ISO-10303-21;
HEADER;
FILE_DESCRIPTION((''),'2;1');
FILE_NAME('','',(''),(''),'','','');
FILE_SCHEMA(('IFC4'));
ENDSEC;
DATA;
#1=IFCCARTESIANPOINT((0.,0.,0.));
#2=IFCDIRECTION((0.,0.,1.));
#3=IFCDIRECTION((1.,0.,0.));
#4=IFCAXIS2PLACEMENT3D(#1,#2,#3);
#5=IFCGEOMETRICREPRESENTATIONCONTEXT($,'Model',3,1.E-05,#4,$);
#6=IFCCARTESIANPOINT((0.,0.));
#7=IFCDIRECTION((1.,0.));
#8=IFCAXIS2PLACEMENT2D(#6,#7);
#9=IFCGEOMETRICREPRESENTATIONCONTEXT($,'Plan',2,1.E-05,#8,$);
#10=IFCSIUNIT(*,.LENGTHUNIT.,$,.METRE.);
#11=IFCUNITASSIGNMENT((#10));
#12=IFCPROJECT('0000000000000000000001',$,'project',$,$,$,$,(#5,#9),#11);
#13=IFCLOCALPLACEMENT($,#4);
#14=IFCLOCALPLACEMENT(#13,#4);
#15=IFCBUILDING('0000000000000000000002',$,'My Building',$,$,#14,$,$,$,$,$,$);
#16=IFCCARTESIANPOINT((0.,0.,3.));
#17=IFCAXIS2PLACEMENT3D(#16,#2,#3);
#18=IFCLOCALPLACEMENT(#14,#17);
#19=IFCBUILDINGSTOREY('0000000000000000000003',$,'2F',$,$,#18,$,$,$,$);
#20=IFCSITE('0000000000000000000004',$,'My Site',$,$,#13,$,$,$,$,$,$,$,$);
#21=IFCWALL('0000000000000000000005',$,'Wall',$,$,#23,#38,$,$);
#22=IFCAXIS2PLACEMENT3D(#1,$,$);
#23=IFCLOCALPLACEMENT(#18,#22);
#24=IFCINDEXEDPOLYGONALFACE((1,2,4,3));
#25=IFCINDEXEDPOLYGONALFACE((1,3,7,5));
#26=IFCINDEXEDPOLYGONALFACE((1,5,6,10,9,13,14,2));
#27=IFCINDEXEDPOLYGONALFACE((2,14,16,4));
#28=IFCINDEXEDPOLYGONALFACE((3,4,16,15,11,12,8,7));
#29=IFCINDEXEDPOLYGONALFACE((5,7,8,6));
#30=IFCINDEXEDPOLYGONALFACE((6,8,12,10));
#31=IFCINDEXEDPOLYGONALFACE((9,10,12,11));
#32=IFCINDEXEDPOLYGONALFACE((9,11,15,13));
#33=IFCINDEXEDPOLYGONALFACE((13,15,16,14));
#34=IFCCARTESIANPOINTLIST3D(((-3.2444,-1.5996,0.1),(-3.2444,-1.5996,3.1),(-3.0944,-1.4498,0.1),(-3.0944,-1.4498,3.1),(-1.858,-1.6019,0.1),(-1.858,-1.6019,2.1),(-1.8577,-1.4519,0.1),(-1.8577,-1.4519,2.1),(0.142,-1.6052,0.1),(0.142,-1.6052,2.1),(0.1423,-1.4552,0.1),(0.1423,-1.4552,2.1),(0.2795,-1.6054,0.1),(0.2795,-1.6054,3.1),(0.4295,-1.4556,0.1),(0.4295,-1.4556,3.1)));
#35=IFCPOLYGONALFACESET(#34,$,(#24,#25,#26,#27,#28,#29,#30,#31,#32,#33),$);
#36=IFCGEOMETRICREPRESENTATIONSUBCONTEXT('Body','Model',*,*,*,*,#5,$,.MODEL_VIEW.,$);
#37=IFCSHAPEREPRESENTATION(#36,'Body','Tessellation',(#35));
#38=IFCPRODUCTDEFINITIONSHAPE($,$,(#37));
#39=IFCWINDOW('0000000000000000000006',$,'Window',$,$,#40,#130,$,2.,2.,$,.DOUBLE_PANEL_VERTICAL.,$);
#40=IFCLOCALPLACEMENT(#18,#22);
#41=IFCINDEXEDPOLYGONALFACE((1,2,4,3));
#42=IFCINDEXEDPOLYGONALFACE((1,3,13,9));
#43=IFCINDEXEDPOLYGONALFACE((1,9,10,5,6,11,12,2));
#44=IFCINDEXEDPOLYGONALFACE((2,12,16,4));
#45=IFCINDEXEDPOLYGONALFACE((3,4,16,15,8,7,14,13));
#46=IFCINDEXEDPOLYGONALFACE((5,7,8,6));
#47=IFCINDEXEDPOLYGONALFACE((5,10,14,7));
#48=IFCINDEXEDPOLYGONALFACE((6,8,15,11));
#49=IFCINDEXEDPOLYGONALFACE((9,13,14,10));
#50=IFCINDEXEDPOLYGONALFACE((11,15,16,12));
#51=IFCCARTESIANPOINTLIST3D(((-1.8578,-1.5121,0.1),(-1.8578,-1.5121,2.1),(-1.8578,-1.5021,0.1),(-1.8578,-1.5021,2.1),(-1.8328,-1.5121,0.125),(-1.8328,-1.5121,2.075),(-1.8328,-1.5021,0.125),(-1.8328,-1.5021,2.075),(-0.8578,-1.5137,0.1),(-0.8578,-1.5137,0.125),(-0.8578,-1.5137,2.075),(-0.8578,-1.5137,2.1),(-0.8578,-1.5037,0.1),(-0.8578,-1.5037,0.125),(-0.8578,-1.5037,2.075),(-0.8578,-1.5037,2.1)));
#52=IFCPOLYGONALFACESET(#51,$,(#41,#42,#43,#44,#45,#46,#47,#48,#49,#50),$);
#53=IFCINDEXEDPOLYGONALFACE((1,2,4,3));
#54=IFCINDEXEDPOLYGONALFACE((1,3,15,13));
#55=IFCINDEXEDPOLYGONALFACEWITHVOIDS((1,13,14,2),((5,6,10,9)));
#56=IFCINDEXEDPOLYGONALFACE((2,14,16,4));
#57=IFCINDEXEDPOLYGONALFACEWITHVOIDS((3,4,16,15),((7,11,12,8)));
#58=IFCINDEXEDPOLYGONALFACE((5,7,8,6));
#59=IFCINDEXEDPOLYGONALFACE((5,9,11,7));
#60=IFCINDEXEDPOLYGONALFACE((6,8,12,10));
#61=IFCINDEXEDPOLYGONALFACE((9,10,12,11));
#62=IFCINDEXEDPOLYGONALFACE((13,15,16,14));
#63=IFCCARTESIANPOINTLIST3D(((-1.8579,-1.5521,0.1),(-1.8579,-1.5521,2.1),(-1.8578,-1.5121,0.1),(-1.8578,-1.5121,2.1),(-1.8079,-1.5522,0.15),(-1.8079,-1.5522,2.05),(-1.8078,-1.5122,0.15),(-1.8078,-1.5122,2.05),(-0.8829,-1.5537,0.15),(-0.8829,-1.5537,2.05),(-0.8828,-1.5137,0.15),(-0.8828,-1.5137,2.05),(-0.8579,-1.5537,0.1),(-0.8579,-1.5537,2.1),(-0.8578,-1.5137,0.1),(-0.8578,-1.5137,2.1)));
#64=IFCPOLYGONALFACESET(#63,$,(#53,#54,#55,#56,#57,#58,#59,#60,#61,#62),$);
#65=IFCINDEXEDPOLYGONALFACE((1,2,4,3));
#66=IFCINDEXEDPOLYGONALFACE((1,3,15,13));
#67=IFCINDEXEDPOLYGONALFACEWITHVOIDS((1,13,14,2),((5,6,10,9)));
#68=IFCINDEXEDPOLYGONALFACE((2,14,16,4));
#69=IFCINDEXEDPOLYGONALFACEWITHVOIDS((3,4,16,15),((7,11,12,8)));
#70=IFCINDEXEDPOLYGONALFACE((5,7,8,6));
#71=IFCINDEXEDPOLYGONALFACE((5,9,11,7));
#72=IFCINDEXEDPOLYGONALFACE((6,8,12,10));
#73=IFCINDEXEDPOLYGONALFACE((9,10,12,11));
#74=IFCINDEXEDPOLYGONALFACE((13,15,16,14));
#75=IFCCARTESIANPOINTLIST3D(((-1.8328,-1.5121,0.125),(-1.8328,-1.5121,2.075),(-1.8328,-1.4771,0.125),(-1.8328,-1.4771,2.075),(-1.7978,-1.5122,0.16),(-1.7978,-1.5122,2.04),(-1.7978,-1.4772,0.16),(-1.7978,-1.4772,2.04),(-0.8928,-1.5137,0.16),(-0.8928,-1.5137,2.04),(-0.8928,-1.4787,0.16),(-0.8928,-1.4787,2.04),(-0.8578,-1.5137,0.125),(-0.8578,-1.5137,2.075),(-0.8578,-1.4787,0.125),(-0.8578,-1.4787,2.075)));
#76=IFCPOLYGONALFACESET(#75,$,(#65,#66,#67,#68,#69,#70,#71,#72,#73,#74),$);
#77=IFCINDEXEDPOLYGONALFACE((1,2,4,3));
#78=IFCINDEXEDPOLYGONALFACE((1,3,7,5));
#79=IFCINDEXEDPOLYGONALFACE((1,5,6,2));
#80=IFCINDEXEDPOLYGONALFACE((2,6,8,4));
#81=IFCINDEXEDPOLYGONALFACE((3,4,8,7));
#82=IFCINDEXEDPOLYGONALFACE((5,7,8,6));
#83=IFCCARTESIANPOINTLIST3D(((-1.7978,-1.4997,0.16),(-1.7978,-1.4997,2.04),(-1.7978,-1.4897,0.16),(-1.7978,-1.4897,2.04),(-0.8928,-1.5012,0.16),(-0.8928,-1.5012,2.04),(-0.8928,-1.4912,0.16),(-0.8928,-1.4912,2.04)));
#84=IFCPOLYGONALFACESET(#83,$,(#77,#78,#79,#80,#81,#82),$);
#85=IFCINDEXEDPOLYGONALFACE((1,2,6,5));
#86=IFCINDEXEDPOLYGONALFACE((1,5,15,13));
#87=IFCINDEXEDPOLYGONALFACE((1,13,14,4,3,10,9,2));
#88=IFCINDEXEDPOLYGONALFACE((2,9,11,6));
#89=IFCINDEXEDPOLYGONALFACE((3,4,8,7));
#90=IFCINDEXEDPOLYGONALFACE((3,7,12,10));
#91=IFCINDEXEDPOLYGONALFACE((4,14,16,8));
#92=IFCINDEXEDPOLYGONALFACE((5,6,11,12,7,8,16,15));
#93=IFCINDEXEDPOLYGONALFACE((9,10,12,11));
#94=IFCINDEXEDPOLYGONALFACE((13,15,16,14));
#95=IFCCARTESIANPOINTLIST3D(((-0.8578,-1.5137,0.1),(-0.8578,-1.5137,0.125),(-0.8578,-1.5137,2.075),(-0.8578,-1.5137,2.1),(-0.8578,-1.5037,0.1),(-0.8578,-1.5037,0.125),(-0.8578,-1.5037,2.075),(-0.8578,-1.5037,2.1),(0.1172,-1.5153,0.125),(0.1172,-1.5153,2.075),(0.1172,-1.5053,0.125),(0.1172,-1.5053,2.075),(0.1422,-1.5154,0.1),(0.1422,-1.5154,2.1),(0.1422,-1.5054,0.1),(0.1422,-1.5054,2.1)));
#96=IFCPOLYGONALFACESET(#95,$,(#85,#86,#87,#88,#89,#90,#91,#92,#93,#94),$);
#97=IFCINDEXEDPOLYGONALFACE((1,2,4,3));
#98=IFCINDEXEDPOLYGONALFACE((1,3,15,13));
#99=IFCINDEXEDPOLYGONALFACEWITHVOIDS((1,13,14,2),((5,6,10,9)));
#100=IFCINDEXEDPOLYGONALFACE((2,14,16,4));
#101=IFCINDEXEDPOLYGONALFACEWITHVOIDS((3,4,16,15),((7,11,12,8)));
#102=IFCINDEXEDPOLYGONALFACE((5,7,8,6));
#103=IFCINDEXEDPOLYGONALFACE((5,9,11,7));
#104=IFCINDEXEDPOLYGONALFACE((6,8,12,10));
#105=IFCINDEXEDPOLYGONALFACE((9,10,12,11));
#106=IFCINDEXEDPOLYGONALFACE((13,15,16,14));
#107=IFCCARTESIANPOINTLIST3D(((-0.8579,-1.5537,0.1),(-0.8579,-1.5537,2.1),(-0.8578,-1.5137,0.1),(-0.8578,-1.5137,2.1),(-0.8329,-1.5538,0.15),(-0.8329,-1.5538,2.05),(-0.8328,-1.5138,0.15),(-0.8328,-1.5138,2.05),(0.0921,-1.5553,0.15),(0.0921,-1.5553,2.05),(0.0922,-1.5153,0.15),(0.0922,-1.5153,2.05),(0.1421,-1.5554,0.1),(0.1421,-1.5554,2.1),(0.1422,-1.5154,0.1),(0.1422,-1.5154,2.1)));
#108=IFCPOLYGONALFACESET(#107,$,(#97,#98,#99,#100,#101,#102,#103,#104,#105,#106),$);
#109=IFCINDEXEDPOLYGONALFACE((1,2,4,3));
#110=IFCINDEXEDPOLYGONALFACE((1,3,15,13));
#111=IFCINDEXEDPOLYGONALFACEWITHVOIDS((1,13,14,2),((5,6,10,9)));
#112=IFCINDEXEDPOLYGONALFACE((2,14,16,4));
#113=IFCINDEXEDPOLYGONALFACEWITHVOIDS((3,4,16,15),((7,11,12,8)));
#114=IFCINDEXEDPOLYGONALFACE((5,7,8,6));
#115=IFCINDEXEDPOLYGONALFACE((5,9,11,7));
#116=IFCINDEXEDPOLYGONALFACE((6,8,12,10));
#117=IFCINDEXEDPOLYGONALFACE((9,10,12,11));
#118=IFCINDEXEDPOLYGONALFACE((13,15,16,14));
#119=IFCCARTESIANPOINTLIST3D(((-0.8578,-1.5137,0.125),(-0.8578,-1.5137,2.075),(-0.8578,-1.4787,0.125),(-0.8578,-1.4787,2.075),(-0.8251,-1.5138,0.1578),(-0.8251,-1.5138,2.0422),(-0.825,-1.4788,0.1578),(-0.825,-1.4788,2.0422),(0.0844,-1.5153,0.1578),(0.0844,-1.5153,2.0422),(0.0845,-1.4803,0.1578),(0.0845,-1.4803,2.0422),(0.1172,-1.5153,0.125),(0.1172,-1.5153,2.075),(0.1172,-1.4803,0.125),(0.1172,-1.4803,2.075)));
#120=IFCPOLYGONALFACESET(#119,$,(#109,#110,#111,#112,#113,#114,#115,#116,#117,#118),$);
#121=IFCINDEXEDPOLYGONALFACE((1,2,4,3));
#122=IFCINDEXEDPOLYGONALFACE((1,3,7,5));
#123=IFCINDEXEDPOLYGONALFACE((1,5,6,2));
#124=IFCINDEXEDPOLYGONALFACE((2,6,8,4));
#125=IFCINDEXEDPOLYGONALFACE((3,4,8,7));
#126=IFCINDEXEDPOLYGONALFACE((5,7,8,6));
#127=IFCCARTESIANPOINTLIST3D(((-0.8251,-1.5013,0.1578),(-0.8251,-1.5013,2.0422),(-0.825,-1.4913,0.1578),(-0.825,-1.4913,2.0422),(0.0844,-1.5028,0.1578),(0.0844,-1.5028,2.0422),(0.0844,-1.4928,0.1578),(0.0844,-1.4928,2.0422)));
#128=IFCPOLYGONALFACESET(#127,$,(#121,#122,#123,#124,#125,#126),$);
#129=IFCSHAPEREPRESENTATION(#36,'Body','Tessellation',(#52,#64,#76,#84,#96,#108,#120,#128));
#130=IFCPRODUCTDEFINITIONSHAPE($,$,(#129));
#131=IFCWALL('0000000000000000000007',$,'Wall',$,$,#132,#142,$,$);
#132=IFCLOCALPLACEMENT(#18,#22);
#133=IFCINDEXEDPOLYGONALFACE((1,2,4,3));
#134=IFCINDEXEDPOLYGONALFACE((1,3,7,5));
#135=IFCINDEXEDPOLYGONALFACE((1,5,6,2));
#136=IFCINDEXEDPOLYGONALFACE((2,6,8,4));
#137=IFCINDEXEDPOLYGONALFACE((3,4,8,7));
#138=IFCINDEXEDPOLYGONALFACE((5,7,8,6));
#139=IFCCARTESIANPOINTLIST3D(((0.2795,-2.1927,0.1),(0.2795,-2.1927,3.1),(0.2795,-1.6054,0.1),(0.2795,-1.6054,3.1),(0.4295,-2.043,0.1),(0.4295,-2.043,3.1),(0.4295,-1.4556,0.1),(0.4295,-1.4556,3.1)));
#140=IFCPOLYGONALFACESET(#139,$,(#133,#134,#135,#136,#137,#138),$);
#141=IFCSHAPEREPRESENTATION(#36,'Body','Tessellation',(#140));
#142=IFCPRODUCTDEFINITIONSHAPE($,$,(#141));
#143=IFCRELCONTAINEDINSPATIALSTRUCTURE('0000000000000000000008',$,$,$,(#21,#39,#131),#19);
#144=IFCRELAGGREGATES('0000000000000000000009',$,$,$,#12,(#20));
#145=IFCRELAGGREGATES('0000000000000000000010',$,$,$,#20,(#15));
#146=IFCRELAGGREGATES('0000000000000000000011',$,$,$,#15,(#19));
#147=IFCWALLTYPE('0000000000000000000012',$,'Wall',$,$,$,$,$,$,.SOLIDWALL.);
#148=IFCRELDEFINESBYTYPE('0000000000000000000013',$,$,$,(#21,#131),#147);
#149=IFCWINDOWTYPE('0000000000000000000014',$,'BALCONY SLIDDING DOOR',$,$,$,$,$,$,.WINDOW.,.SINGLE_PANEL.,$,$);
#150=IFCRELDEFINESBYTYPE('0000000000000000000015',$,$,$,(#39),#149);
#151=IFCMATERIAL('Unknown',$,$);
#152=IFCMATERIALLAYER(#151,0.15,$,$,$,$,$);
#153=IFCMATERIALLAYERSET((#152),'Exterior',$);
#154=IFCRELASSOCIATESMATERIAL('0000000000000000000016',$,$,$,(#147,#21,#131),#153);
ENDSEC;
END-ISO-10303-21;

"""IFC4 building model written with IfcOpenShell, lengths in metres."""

from ifc_helpers import new_model, entity, si_unit, frame, origin_with_axes, origin_2d_with_axis, place, context, subcontext, project, spatial, line, indexed_curve, outline, extrude, shape, source, transform, mapped, material, layer, layer_set, layer_usage, type_object, type_shapes, element, fill, save


model = new_model("IFC4")

# Units and contexts
model_context = context("Model", 3, precision=1e-05, world=origin_with_axes())
plan_context = context("Plan", 2, precision=1e-05, world=origin_2d_with_axis())
body_context_1 = subcontext(model_context, "Body", "Model", "MODEL_VIEW")
body_context_2 = subcontext(plan_context, "Body", "Plan", "PLAN_VIEW")
ifc_project = project(units=[si_unit("LENGTHUNIT", "METRE")], contexts=[model_context, plan_context])

# Site, building, storey
site_placement = place(None, origin_with_axes())
site = spatial("IfcSite", under=ifc_project, at=site_placement, Name="My Site")
building_placement = place(site_placement, origin_with_axes())
building = spatial("IfcBuilding", under=site, at=building_placement, Name="My Building")
storey_placement = place(building_placement, frame((0.0, 0.0, 3.0), z_axis=(0.0, 0.0, 1.0), x_axis=(1.0, 0.0, 0.0)))
storey = spatial("IfcBuildingStorey", under=building, at=storey_placement, Name="2F")

# Shared definitions
ifc_material = material(Name="Unknown")

# Shared definitions
ifc_layer_1 = layer(ifc_material, 0.15)
ifc_layer_set_1 = layer_set([ifc_layer_1], Name="Exterior")
wall_type_1 = type_object("IfcWallType", Name="Wall", PredefinedType="SOLIDWALL", material=ifc_layer_set_1)

# Wall, opening, window
ifc_layer_usage_1 = layer_usage(ifc_layer_set_1, "AXIS2", "POSITIVE", 0.0)
wall_1_placement = place(storey_placement, frame((-3.2444, -1.5996, 0.1), z_axis=(0.0, 0.0, 1.0), x_axis=(0.999999, -0.00165, 0.0)))
wall_1 = element("IfcWall", 1, at=wall_1_placement, inside=storey, type_object=wall_type_1, material=ifc_layer_usage_1, Name="Wall", context=body_context_1, shape_type="SweptSolid", body=[
    extrude(outline(indexed_curve([(0.0, 0.0), (0.1498, 0.15), (3.6737, 0.15), (3.5239, 0.0)], segments=[line(1, 2, 3, 4, 1)])), origin_with_axes(), (0.0, 0.0, 1.0), 3.0),
])
shared_shape_1 = source(origin_with_axes(), body_context_1, "Body", "SweptSolid", [
    extrude(outline(indexed_curve([(0.0, 0.0), (2.0, 0.0), (2.0, 2.0), (0.0, 2.0)], segments=[line(1, 2, 3, 4, 1)])), frame((0.0, -0.6, 0.0), z_axis=(0.0, -1.0, 0.0), x_axis=(1.0, 0.0, 0.0)), (0.0, 0.0, -1.0), 1.2),
])
opening_1_placement = place(wall_1_placement, frame((1.3864, -0.0002, 0.0), z_axis=(0.0, 0.0, 1.0), x_axis=(1.0, 0.0, 0.0)))
opening_1 = element("IfcOpeningElement", 2, at=opening_1_placement, cuts=wall_1, PredefinedType="OPENING", context=body_context_1, shape_type="MappedRepresentation", body=[
    mapped(shared_shape_1, transform((0.0, 0.0, 0.0), x_axis=(1.0, 0.0, 0.0), y_axis=(0.0, 1.0, 0.0), z_axis=(0.0, 0.0, 1.0), scale=1.0)),
])
window_type_1 = type_object("IfcWindowType", Name="BALCONY SLIDDING DOOR", PartitioningType="SINGLE_PANEL", PredefinedType="WINDOW")
shared_shape_2 = source(origin_with_axes(), body_context_1, "Body", "SweptSolid", [
    extrude(outline(indexed_curve([(1.0, 0.0), (0.0, 0.0), (0.0, 2.0), (1.0, 2.0), (1.0, 1.975), (0.025, 1.975), (0.025, 0.025), (1.0, 0.025)], segments=[line(1, 2, 3, 4, 5, 6, 7, 8, 1)])), frame((0.0, 0.09, 0.0), z_axis=(0.0, -1.0, 0.0), x_axis=(1.0, 0.0, 0.0)), (0.0, 0.0, -1.0), 0.01),
    extrude(outline(indexed_curve([(0.0, 0.0), (1.0, 0.0), (1.0, 2.0), (0.0, 2.0)], segments=[line(1, 2, 3, 4, 1)]), holes=[indexed_curve([(0.05, 0.05), (0.975, 0.05), (0.975, 1.95), (0.05, 1.95)], segments=[line(1, 2, 3, 4, 1)])]), frame((0.0, 0.05, 0.0), z_axis=(0.0, -1.0, 0.0), x_axis=(1.0, 0.0, 0.0)), (0.0, 0.0, -1.0), 0.04),
    extrude(outline(indexed_curve([(0.0, 0.0), (0.975, 0.0), (0.975, 1.95), (0.0, 1.95)], segments=[line(1, 2, 3, 4, 1)]), holes=[indexed_curve([(0.035, 0.035), (0.94, 0.035), (0.94, 1.915), (0.035, 1.915)], segments=[line(1, 2, 3, 4, 1)])]), frame((0.025, 0.09, 0.025), z_axis=(0.0, -1.0, 0.0), x_axis=(1.0, 0.0, 0.0)), (0.0, 0.0, -1.0), 0.035),
    extrude(outline(indexed_curve([(0.035, 0.035), (0.94, 0.035), (0.94, 1.915), (0.035, 1.915)], segments=[line(1, 2, 3, 4, 1)])), frame((0.025, 0.1025, 0.025), z_axis=(0.0, -1.0, 0.0), x_axis=(1.0, 0.0, 0.0)), (0.0, 0.0, -1.0), 0.01),
    extrude(outline(indexed_curve([(0.0, 2.0), (1.0, 2.0), (1.0, 0.0), (0.0, 0.0), (0.0, 0.025), (0.975, 0.025), (0.975, 1.975), (0.0, 1.975)], segments=[line(1, 2, 3, 4, 5, 6, 7, 8, 1)])), frame((1.0, 0.09, 0.0), z_axis=(0.0, -1.0, 0.0), x_axis=(1.0, 0.0, 0.0)), (0.0, 0.0, -1.0), 0.01),
    extrude(outline(indexed_curve([(0.0, 0.0), (1.0, 0.0), (1.0, 2.0), (0.0, 2.0)], segments=[line(1, 2, 3, 4, 1)]), holes=[indexed_curve([(0.025, 0.05), (0.95, 0.05), (0.95, 1.95), (0.025, 1.95)], segments=[line(1, 2, 3, 4, 1)])]), frame((1.0, 0.05, 0.0), z_axis=(0.0, -1.0, 0.0), x_axis=(1.0, 0.0, 0.0)), (0.0, 0.0, -1.0), 0.04),
    extrude(outline(indexed_curve([(0.0, 0.0), (0.975, 0.0), (0.975, 1.95), (0.0, 1.95)], segments=[line(1, 2, 3, 4, 1)]), holes=[indexed_curve([(0.0328, 0.0328), (0.9422, 0.0328), (0.9422, 1.9172), (0.0328, 1.9172)], segments=[line(1, 2, 3, 4, 1)])]), frame((1.0, 0.09, 0.025), z_axis=(0.0, -1.0, 0.0), x_axis=(1.0, 0.0, 0.0)), (0.0, 0.0, -1.0), 0.035),
    extrude(outline(indexed_curve([(0.0328, 0.0328), (0.9422, 0.0328), (0.9422, 1.9172), (0.0328, 1.9172)], segments=[line(1, 2, 3, 4, 1)])), frame((1.0, 0.1025, 0.025), z_axis=(0.0, -1.0, 0.0), x_axis=(1.0, 0.0, 0.0)), (0.0, 0.0, -1.0), 0.01),
])
shared_shape_3 = source(origin_with_axes(), body_context_2, "Body", "Curve2D", [
    entity("IfcIndexedPolyCurve", entity("IfcCartesianPointList2D", [[0.05, 0.05], [0.975, 0.05]])),
    entity("IfcIndexedPolyCurve", entity("IfcCartesianPointList2D", [[0.0, 0.1], [0.025, 0.1], [0.025, 0.09], [0.05, 0.09], [0.05, 0.05], [0.0, 0.05]]), [entity("IfcLineIndex", [1, 2, 3, 4, 5, 6, 1])]),
    entity("IfcIndexedPolyCurve", entity("IfcCartesianPointList2D", [[1.0, 0.1], [1.0, 0.1], [1.0, 0.09], [0.975, 0.09], [0.975, 0.05], [1.0, 0.05]])),
    entity("IfcIndexedPolyCurve", entity("IfcCartesianPointList2D", [[0.025, 0.09], [0.06, 0.09], [0.06, 0.125], [0.025, 0.125]]), [entity("IfcLineIndex", [1, 2, 3, 4, 1])]),
    entity("IfcIndexedPolyCurve", entity("IfcCartesianPointList2D", [[1.0, 0.09], [0.965, 0.09], [0.965, 0.125], [1.0, 0.125]]), [entity("IfcLineIndex", [1, 2, 3, 4, 1])]),
    entity("IfcIndexedPolyCurve", entity("IfcCartesianPointList2D", [[0.06, 0.09], [0.965, 0.09]])),
    entity("IfcIndexedPolyCurve", entity("IfcCartesianPointList2D", [[0.06, 0.125], [0.965, 0.125]])),
    entity("IfcIndexedPolyCurve", entity("IfcCartesianPointList2D", [[0.06, 0.1075], [0.965, 0.1075]])),
    entity("IfcIndexedPolyCurve", entity("IfcCartesianPointList2D", [[1.025, 0.05], [1.95, 0.05]])),
    entity("IfcIndexedPolyCurve", entity("IfcCartesianPointList2D", [[1.0, 0.1], [1.0, 0.1], [1.0, 0.09], [1.025, 0.09], [1.025, 0.05], [1.0, 0.05]])),
    entity("IfcIndexedPolyCurve", entity("IfcCartesianPointList2D", [[2.0, 0.1], [1.975, 0.1], [1.975, 0.09], [1.95, 0.09], [1.95, 0.05], [2.0, 0.05]]), [entity("IfcLineIndex", [1, 2, 3, 4, 5, 6, 1])]),
    entity("IfcIndexedPolyCurve", entity("IfcCartesianPointList2D", [[1.0, 0.09], [1.0328, 0.09], [1.0328, 0.125], [1.0, 0.125]]), [entity("IfcLineIndex", [1, 2, 3, 4, 1])]),
    entity("IfcIndexedPolyCurve", entity("IfcCartesianPointList2D", [[1.975, 0.09], [1.9422, 0.09], [1.9422, 0.125], [1.975, 0.125]]), [entity("IfcLineIndex", [1, 2, 3, 4, 1])]),
    entity("IfcIndexedPolyCurve", entity("IfcCartesianPointList2D", [[1.0328, 0.09], [1.9422, 0.09]])),
    entity("IfcIndexedPolyCurve", entity("IfcCartesianPointList2D", [[1.0328, 0.125], [1.9422, 0.125]])),
    entity("IfcIndexedPolyCurve", entity("IfcCartesianPointList2D", [[1.0328, 0.1075], [1.9422, 0.1075]])),
])
type_shapes(window_type_1, [shared_shape_2, shared_shape_3])
window_1_placement = place(opening_1_placement, frame((0.0, 0.0, 0.0), z_axis=(0.0, 0.0, 1.0), x_axis=(1.0, 0.0, 0.0)))
window_1 = element("IfcWindow", 3, at=window_1_placement, inside=storey, type_object=window_type_1, Name="Window", OverallHeight=2.0, OverallWidth=2.0, PartitioningType="DOUBLE_PANEL_VERTICAL", shapes=[
    shape(body_context_1, "Body", "MappedRepresentation", [mapped(shared_shape_2, transform((0.0, 0.0, 0.0), x_axis=(1.0, 0.0, 0.0), y_axis=(0.0, 1.0, 0.0), z_axis=(0.0, 0.0, 1.0), scale=1.0))]),
    shape(body_context_2, "Body", "MappedRepresentation", [mapped(shared_shape_3, transform((0.0, 0.0, 0.0), x_axis=(1.0, 0.0, 0.0), y_axis=(0.0, 1.0, 0.0), z_axis=(0.0, 0.0, 1.0), scale=1.0))]),
])
fill(opening_1, window_1)

# Wall
ifc_layer_usage_2 = layer_usage(ifc_layer_set_1, "AXIS2", "POSITIVE", 0.0)
wall_2_placement = place(storey_placement, frame((0.2795, -1.6054, 0.1), z_axis=(0.0, 0.0, 1.0), x_axis=(0.0, -1.0, 0.0)))
element("IfcWall", 4, at=wall_2_placement, inside=storey, type_object=wall_type_1, material=ifc_layer_usage_2, Name="Wall", context=body_context_1, shape_type="SweptSolid", body=[
    extrude(outline(indexed_curve([(0.0, 0.0), (-0.1498, 0.15), (0.4377, 0.15), (0.5873, 0.0)], segments=[line(1, 2, 3, 4, 1)])), origin_with_axes(), (0.0, 0.0, 1.0), 3.0),
])

save(model, "model.ifc")
